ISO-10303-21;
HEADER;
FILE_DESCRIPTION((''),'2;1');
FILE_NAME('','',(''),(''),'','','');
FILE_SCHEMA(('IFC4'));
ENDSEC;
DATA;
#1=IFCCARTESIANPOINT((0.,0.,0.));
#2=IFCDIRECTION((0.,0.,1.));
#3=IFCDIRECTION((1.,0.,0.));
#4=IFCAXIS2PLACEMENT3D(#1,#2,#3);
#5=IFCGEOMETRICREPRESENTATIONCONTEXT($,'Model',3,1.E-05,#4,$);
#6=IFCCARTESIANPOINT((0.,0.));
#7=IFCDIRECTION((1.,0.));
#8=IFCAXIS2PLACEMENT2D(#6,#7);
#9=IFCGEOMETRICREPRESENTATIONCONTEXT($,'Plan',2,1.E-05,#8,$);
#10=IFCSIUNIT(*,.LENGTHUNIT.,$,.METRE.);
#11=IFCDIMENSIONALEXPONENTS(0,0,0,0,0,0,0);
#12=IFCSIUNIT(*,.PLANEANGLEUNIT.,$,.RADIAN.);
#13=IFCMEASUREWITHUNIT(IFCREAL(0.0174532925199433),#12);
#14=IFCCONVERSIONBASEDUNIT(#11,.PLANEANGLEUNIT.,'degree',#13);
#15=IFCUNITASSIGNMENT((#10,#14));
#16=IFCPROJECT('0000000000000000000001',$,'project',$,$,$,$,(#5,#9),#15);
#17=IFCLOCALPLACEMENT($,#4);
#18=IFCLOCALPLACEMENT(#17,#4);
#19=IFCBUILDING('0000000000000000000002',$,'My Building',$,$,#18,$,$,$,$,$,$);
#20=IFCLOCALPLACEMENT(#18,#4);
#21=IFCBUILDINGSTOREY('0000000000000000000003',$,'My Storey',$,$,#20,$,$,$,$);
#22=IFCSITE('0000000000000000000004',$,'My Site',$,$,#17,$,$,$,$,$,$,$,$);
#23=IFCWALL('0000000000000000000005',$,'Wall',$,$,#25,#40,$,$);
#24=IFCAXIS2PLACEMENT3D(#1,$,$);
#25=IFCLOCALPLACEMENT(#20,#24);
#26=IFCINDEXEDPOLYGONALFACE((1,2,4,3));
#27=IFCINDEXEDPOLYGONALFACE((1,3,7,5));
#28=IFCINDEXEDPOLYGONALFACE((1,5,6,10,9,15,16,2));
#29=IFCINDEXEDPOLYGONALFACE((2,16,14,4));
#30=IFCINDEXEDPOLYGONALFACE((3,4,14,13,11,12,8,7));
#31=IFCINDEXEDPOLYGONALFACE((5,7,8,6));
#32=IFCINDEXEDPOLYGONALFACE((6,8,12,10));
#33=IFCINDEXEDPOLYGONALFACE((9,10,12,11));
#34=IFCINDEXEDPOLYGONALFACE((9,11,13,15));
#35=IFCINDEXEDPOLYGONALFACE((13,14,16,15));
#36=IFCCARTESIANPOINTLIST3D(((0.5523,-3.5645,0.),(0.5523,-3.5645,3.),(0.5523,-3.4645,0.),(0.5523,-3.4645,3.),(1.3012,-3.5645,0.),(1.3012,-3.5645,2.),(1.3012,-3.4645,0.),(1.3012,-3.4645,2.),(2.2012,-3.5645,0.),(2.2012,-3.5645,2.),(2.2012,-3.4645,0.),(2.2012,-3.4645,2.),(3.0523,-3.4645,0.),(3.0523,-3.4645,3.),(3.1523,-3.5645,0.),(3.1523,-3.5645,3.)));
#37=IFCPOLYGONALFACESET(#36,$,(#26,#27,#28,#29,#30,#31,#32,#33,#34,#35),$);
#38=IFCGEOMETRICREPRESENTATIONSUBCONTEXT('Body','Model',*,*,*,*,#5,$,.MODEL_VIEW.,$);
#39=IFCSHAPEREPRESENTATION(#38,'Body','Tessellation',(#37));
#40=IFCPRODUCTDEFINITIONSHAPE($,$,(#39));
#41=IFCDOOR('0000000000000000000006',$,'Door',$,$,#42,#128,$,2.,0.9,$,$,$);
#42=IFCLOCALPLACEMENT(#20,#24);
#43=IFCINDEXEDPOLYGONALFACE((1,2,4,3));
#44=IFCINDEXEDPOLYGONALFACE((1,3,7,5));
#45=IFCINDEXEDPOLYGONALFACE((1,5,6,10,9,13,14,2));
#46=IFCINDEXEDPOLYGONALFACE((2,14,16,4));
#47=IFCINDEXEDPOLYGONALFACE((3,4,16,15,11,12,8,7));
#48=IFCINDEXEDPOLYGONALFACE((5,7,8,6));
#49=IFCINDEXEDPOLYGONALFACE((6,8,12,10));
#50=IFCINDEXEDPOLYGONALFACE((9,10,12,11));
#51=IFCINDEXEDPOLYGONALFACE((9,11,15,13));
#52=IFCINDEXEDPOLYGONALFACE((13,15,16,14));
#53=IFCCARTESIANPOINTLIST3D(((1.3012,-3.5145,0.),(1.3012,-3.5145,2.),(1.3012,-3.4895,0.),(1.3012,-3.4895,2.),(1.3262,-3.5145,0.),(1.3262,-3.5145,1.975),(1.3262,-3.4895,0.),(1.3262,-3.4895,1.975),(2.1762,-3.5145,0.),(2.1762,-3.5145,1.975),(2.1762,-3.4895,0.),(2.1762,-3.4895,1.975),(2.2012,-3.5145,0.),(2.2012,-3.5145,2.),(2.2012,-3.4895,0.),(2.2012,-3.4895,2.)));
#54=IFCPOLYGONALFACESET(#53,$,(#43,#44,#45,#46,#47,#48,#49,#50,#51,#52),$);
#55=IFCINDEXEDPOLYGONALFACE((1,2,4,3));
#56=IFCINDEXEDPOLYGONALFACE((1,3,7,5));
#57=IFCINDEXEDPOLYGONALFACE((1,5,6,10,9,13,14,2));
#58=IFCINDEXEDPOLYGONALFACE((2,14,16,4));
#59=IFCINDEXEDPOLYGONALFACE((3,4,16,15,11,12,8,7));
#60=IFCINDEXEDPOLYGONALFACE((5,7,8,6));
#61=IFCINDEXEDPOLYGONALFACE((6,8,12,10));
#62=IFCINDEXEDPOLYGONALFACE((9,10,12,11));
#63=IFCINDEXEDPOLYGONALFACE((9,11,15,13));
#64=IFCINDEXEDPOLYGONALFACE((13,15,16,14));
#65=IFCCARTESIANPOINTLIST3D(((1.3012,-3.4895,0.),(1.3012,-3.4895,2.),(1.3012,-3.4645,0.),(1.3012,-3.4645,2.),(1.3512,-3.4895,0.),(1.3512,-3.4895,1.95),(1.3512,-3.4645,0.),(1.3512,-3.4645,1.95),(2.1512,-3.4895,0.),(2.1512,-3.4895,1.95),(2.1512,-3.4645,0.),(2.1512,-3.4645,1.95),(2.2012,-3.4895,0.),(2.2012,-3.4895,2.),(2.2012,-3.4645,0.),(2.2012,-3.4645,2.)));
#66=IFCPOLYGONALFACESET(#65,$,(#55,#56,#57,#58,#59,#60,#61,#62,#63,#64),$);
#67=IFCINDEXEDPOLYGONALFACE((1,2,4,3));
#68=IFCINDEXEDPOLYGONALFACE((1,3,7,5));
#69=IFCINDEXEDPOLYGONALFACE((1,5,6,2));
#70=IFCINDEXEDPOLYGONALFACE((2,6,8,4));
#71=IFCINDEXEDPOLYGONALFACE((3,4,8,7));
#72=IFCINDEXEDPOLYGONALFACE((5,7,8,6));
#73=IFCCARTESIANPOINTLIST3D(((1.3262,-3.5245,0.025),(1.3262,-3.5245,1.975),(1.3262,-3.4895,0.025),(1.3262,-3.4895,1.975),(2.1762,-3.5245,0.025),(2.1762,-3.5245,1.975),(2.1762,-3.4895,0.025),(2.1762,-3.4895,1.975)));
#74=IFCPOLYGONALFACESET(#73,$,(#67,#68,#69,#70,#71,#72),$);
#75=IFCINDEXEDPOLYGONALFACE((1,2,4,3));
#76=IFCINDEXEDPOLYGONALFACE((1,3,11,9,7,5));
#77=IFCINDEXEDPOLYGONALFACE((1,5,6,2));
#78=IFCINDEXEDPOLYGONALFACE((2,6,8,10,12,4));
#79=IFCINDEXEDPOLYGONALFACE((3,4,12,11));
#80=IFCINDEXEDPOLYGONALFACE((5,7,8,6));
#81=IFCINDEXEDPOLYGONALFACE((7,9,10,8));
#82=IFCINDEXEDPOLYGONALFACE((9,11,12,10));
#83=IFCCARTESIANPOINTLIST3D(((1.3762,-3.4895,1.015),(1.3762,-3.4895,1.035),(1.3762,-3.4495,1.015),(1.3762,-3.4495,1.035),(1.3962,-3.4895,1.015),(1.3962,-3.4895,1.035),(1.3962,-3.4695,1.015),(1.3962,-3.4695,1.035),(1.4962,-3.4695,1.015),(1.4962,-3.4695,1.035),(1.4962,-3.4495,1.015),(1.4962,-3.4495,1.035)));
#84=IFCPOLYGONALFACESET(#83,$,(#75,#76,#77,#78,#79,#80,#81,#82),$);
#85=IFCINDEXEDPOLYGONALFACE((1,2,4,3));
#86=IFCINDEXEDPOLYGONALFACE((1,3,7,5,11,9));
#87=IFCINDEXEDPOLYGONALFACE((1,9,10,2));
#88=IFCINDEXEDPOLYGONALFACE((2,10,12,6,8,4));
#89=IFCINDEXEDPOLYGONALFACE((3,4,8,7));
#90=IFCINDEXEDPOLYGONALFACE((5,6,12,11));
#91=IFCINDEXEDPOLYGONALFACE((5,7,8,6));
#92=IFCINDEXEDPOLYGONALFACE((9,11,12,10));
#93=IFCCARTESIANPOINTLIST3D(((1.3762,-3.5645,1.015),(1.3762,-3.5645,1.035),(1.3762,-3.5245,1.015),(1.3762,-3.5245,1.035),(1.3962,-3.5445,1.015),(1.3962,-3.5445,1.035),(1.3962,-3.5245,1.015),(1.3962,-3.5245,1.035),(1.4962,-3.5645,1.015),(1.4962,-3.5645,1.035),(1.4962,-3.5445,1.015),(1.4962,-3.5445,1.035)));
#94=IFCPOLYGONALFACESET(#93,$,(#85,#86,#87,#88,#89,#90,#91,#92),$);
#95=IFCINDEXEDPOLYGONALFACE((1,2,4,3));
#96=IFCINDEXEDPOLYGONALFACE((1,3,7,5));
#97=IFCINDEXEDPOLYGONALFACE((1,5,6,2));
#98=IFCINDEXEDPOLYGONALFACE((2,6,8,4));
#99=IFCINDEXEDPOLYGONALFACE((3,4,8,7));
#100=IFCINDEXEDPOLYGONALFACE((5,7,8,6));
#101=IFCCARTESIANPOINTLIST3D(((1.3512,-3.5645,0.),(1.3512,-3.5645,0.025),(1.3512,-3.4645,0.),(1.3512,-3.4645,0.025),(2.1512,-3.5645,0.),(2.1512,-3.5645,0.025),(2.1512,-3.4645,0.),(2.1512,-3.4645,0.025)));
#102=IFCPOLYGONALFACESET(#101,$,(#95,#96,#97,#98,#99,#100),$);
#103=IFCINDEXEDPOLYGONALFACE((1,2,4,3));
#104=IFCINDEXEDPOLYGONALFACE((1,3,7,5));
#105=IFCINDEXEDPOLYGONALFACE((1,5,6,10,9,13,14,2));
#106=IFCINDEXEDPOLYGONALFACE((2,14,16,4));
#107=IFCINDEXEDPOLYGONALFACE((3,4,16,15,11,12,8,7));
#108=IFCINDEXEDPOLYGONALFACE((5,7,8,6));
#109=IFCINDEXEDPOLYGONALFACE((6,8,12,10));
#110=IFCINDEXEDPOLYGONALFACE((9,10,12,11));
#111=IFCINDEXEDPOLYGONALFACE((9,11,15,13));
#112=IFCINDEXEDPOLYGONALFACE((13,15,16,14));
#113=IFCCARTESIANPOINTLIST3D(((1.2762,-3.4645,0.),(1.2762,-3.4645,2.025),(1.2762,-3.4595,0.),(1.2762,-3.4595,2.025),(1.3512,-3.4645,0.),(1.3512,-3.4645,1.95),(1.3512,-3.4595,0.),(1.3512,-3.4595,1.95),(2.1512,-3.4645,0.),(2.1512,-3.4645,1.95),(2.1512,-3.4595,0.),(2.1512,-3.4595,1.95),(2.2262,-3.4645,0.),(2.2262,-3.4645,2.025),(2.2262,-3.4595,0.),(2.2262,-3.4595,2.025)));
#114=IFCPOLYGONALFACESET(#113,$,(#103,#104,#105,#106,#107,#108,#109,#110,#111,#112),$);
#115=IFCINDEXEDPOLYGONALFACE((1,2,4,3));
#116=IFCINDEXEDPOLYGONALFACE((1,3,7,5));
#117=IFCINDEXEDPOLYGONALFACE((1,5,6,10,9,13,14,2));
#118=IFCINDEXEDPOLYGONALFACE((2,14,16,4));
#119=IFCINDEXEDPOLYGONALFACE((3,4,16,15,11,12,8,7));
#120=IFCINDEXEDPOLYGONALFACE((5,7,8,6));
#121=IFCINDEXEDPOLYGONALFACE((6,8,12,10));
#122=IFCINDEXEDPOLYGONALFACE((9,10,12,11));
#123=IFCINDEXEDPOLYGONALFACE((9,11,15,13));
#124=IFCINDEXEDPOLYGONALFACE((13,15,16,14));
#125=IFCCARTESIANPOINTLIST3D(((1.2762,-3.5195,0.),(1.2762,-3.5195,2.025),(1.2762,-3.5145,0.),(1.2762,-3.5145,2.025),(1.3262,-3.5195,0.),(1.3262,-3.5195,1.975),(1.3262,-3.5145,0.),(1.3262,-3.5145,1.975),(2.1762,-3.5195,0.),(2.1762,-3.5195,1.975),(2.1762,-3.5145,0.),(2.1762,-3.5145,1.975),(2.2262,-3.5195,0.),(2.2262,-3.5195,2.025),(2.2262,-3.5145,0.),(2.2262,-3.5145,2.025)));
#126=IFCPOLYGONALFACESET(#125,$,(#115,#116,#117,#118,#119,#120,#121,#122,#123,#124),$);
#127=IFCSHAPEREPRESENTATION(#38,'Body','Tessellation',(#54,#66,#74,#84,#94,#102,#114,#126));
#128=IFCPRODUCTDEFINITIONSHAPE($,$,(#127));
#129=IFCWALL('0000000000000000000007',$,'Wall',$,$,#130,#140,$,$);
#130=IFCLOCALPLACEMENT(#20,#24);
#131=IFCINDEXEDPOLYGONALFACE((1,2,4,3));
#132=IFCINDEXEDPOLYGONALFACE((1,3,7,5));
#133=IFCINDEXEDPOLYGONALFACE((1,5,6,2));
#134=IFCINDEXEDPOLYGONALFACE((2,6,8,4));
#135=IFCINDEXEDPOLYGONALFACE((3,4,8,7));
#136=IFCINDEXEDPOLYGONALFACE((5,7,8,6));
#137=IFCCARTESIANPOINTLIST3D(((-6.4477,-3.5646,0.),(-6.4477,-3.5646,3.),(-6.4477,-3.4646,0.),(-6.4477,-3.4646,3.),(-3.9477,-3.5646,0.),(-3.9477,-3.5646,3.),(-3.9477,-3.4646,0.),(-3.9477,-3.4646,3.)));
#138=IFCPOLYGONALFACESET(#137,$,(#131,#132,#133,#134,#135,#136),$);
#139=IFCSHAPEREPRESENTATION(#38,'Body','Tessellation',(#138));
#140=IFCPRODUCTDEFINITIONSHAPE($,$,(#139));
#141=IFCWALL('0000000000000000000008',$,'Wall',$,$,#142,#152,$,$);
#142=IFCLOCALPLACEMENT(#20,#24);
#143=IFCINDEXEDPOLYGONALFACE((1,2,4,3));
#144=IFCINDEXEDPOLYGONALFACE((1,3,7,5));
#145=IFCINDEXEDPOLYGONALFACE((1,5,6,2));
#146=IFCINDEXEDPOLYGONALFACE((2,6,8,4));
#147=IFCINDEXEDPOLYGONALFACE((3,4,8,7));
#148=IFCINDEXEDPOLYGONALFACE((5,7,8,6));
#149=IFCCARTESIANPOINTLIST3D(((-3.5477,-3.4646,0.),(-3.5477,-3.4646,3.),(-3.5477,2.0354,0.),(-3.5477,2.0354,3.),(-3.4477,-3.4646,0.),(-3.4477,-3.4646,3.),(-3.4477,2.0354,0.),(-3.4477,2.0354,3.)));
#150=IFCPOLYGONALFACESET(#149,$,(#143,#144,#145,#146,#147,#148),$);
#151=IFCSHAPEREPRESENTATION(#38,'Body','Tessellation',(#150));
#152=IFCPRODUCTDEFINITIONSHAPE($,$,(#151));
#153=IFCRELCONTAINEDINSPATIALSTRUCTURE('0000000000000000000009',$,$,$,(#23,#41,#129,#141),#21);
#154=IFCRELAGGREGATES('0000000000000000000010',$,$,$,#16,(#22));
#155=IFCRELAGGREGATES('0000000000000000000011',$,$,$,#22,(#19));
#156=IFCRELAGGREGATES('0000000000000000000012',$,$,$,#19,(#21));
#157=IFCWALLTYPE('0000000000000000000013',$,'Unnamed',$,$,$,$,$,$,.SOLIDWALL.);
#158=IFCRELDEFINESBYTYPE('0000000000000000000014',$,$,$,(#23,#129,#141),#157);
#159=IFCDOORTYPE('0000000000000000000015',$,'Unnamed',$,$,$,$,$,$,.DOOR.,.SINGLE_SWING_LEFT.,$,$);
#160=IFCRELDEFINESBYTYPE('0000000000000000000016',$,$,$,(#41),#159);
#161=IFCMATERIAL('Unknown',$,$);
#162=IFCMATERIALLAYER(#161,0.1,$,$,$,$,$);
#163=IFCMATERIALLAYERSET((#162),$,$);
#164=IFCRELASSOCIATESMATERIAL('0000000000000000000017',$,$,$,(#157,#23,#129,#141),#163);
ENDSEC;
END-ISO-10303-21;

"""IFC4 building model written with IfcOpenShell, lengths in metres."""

from ifc_helpers import new_model, entity, si_unit, converted_unit, frame, origin_with_axes, origin_2d_with_axis, place, context, subcontext, project, spatial, line, indexed_curve, outline, extrude, shape, source, transform, mapped, material, layer, layer_set, layer_usage, type_object, type_shapes, element, fill, save


model = new_model("IFC4")

# Units and contexts
model_context = context("Model", 3, precision=1e-05, world=origin_with_axes())
plan_context = context("Plan", 2, precision=1e-05, world=origin_2d_with_axis())
body_context_1 = subcontext(model_context, "Body", "Model", "MODEL_VIEW")
body_context_2 = subcontext(plan_context, "Body", "Plan", "PLAN_VIEW")
ifc_project = project(units=[si_unit("LENGTHUNIT", "METRE"), converted_unit("PLANEANGLEUNIT", "degree", entity("IfcReal", 0.0174532925199433), si_unit("PLANEANGLEUNIT", "RADIAN"), dimensions=[0, 0, 0, 0, 0, 0, 0])], contexts=[model_context, plan_context])

# Site, building, storey
site_placement = place(None, origin_with_axes())
site = spatial("IfcSite", under=ifc_project, at=site_placement, Name="My Site")
building_placement = place(site_placement, origin_with_axes())
building = spatial("IfcBuilding", under=site, at=building_placement, Name="My Building")
storey_placement = place(building_placement, origin_with_axes())
storey = spatial("IfcBuildingStorey", under=building, at=storey_placement, Name="My Storey")

# Shared definitions
ifc_material = material(Name="Unknown")

# Shared definitions
ifc_layer_1 = layer(ifc_material, 0.1)
ifc_layer_set_1 = layer_set([ifc_layer_1])
wall_type = type_object("IfcWallType", Name="Unnamed", PredefinedType="SOLIDWALL", material=ifc_layer_set_1)

# Wall, opening, door
ifc_layer_usage_1 = layer_usage(ifc_layer_set_1, "AXIS2", "POSITIVE", 0.0)
wall_1_placement = place(storey_placement, frame((3.0523, -3.4645, 0.0), z_axis=(0.0, 0.0, 1.0), x_axis=(-1.0, 0.0, 0.0)))
wall_1 = element("IfcWall", 1, at=wall_1_placement, inside=storey, type_object=wall_type, material=ifc_layer_usage_1, Name="Wall", context=body_context_1, shape_type="SweptSolid", body=[
    extrude(outline(indexed_curve([(0.0, 0.0), (-0.1, 0.1), (2.5, 0.1), (2.5, 0.0)], segments=[line(1, 2, 3, 4, 1)])), origin_with_axes(), (0.0, 0.0, 1.0), 3.0),
])
shared_shape_1 = source(origin_with_axes(), body_context_1, "Body", "SweptSolid", [
    extrude(outline(indexed_curve([(0.0, 0.0), (0.9, 0.0), (0.9, 2.0), (0.0, 2.0)], segments=[line(1, 2, 3, 4, 1)])), frame((0.0, -0.6, 0.0), z_axis=(0.0, -1.0, 0.0), x_axis=(1.0, 0.0, 0.0)), (0.0, 0.0, -1.0), 1.2),
])
opening_1_placement = place(wall_1_placement, frame((0.8511, 0.0, 0.0), z_axis=(0.0, 0.0, 1.0), x_axis=(1.0, 0.0, 0.0)))
opening_1 = element("IfcOpeningElement", 2, at=opening_1_placement, cuts=wall_1, PredefinedType="OPENING", context=body_context_1, shape_type="MappedRepresentation", body=[
    mapped(shared_shape_1, transform((0.0, 0.0, 0.0), x_axis=(1.0, 0.0, 0.0), y_axis=(0.0, 1.0, 0.0), z_axis=(0.0, 0.0, 1.0), scale=1.0)),
])
door_type = type_object("IfcDoorType", Name="Unnamed", OperationType="SINGLE_SWING_LEFT", PredefinedType="DOOR")
shared_shape_2 = source(origin_with_axes(), body_context_1, "Body", "SweptSolid", [
    extrude(outline(indexed_curve([(0.0, 0.0), (0.0, 2.0), (0.9, 2.0), (0.9, 0.0), (0.875, 0.0), (0.875, 1.975), (0.025, 1.975), (0.025, 0.0)], segments=[line(1, 2, 3, 4, 5, 6, 7, 8, 1)])), frame((0.0, 0.025, 0.0), z_axis=(0.0, -1.0, 0.0), x_axis=(1.0, 0.0, 0.0)), (0.0, 0.0, -1.0), 0.025),
    extrude(outline(indexed_curve([(0.0, 0.0), (0.0, 2.0), (0.9, 2.0), (0.9, 0.0), (0.85, 0.0), (0.85, 1.95), (0.05, 1.95), (0.05, 0.0)], segments=[line(1, 2, 3, 4, 5, 6, 7, 8, 1)])), frame((0.0, 0.0, 0.0), z_axis=(0.0, -1.0, 0.0), x_axis=(1.0, 0.0, 0.0)), (0.0, 0.0, -1.0), 0.025),
    extrude(outline(indexed_curve([(0.0, 0.0), (0.85, 0.0), (0.85, 0.035), (0.0, 0.035)], segments=[line(1, 2, 3, 4, 1)])), frame((0.025, 0.025, 0.025), z_axis=(0.0, 0.0, 1.0), x_axis=(1.0, 0.0, 0.0)), (0.0, 0.0, 1.0), 1.95),
    extrude(outline(indexed_curve([(0.0, 0.0), (0.0, -0.04), (-0.12, -0.04), (-0.12, -0.02), (-0.02, -0.02), (-0.02, 0.0)], segments=[line(1, 2, 3, 4, 5, 6, 1)])), frame((0.825, 0.025, 1.015), z_axis=(0.0, 0.0, 1.0), x_axis=(1.0, 0.0, 0.0)), (0.0, 0.0, 1.0), 0.02),
    extrude(outline(indexed_curve([(0.0, 0.0), (0.0, 0.04), (-0.12, 0.04), (-0.12, 0.02), (-0.02, 0.02), (-0.02, 0.0)], segments=[line(1, 2, 3, 4, 5, 6, 1)])), frame((0.825, 0.06, 1.015), z_axis=(0.0, 0.0, 1.0), x_axis=(1.0, 0.0, 0.0)), (0.0, 0.0, 1.0), 0.02),
    extrude(outline(indexed_curve([(0.0, 0.0), (0.8, 0.0), (0.8, 0.1), (0.0, 0.1)], segments=[line(1, 2, 3, 4, 1)])), frame((0.05, 0.0, 0.0), z_axis=(0.0, 0.0, 1.0), x_axis=(1.0, 0.0, 0.0)), (0.0, 0.0, 1.0), 0.025),
    extrude(outline(indexed_curve([(0.0, 0.0), (0.0, 2.025), (0.95, 2.025), (0.95, 0.0), (0.875, 0.0), (0.875, 1.95), (0.075, 1.95), (0.075, 0.0)], segments=[line(1, 2, 3, 4, 5, 6, 7, 8, 1)])), frame((-0.025, -0.005, 0.0), z_axis=(0.0, -1.0, 0.0), x_axis=(1.0, 0.0, 0.0)), (0.0, 0.0, -1.0), 0.005),
    extrude(outline(indexed_curve([(0.0, 0.0), (0.0, 2.025), (0.95, 2.025), (0.95, 0.0), (0.9, 0.0), (0.9, 1.975), (0.05, 1.975), (0.05, 0.0)], segments=[line(1, 2, 3, 4, 5, 6, 7, 8, 1)])), frame((-0.025, 0.05, 0.0), z_axis=(0.0, -1.0, 0.0), x_axis=(1.0, 0.0, 0.0)), (0.0, 0.0, -1.0), 0.005),
])
shared_shape_3 = source(origin_with_axes(), body_context_2, "Body", "Curve2D", [
    entity("IfcIndexedPolyCurve", entity("IfcCartesianPointList2D", [[0.0, 0.0], [0.0, 0.05], [0.025, 0.05], [0.025, 0.025], [0.05, 0.025], [0.05, 0.0]]), [entity("IfcLineIndex", [1, 2, 3, 4, 5, 6, 1])]),
    entity("IfcIndexedPolyCurve", entity("IfcCartesianPointList2D", [[0.9, 0.0], [0.9, 0.05], [0.875, 0.05], [0.875, 0.025], [0.85, 0.025], [0.85, 0.0]]), [entity("IfcLineIndex", [1, 2, 3, 4, 5, 6, 1])]),
    entity("IfcTrimmedCurve", entity("IfcEllipse", entity("IfcAxis2Placement2D", entity("IfcCartesianPoint", [0.06, 0.05]), entity("IfcDirection", [1.0, 0.0])), 0.815, 0.85), [entity("IfcCartesianPoint", [0.875, 0.05])], [entity("IfcCartesianPoint", [0.06, 0.9])], True, "CARTESIAN"),
    entity("IfcIndexedPolyCurve", entity("IfcCartesianPointList2D", [[0.025, 0.05], [0.06, 0.05], [0.06, 0.9], [0.025, 0.9]]), [entity("IfcLineIndex", [1, 2, 3, 4, 1])]),
])
type_shapes(door_type, [shared_shape_2, shared_shape_3])
door_1_placement = place(opening_1_placement, frame((0.0, 0.0, 0.0), z_axis=(0.0, 0.0, 1.0), x_axis=(1.0, 0.0, 0.0)))
door_1 = element("IfcDoor", 3, at=door_1_placement, inside=storey, type_object=door_type, Name="Door", OverallHeight=2.0, OverallWidth=0.9, shapes=[
    shape(body_context_1, "Body", "MappedRepresentation", [mapped(shared_shape_2, transform((0.0, 0.0, 0.0), x_axis=(1.0, 0.0, 0.0), y_axis=(0.0, 1.0, 0.0), z_axis=(0.0, 0.0, 1.0), scale=1.0))]),
    shape(body_context_2, "Body", "MappedRepresentation", [mapped(shared_shape_3, transform((0.0, 0.0, 0.0), x_axis=(1.0, 0.0, 0.0), y_axis=(0.0, 1.0, 0.0), z_axis=(0.0, 0.0, 1.0), scale=1.0))]),
])
fill(opening_1, door_1)

# Walls
ifc_layer_usage_2 = layer_usage(ifc_layer_set_1, "AXIS2", "POSITIVE", 0.0)
wall_2_placement = place(storey_placement, frame((-3.9477, -3.4646, 0.0), z_axis=(0.0, 0.0, 1.0), x_axis=(-1.0, 0.0, 0.0)))
element("IfcWall", 4, at=wall_2_placement, inside=storey, type_object=wall_type, material=ifc_layer_usage_2, Name="Wall", context=body_context_1, shape_type="SweptSolid", body=[
    extrude(outline(indexed_curve([(0.0, 0.0), (0.0, 0.1), (2.5, 0.1), (2.5, 0.0)], segments=[line(1, 2, 3, 4, 1)])), origin_with_axes(), (0.0, 0.0, 1.0), 3.0),
])
ifc_layer_usage_3 = layer_usage(ifc_layer_set_1, "AXIS2", "POSITIVE", 0.0)
wall_3_placement = place(storey_placement, frame((-3.4477, -3.4646, 0.0), z_axis=(0.0, 0.0, 1.0), x_axis=(0.0, 1.0, 0.0)))
element("IfcWall", 5, at=wall_3_placement, inside=storey, type_object=wall_type, material=ifc_layer_usage_3, Name="Wall", context=body_context_1, shape_type="SweptSolid", body=[
    extrude(outline(indexed_curve([(0.0, 0.0), (0.0, 0.1), (5.5, 0.1), (5.5, 0.0)], segments=[line(1, 2, 3, 4, 1)])), origin_with_axes(), (0.0, 0.0, 1.0), 3.0),
])

save(model, "model.ifc")
